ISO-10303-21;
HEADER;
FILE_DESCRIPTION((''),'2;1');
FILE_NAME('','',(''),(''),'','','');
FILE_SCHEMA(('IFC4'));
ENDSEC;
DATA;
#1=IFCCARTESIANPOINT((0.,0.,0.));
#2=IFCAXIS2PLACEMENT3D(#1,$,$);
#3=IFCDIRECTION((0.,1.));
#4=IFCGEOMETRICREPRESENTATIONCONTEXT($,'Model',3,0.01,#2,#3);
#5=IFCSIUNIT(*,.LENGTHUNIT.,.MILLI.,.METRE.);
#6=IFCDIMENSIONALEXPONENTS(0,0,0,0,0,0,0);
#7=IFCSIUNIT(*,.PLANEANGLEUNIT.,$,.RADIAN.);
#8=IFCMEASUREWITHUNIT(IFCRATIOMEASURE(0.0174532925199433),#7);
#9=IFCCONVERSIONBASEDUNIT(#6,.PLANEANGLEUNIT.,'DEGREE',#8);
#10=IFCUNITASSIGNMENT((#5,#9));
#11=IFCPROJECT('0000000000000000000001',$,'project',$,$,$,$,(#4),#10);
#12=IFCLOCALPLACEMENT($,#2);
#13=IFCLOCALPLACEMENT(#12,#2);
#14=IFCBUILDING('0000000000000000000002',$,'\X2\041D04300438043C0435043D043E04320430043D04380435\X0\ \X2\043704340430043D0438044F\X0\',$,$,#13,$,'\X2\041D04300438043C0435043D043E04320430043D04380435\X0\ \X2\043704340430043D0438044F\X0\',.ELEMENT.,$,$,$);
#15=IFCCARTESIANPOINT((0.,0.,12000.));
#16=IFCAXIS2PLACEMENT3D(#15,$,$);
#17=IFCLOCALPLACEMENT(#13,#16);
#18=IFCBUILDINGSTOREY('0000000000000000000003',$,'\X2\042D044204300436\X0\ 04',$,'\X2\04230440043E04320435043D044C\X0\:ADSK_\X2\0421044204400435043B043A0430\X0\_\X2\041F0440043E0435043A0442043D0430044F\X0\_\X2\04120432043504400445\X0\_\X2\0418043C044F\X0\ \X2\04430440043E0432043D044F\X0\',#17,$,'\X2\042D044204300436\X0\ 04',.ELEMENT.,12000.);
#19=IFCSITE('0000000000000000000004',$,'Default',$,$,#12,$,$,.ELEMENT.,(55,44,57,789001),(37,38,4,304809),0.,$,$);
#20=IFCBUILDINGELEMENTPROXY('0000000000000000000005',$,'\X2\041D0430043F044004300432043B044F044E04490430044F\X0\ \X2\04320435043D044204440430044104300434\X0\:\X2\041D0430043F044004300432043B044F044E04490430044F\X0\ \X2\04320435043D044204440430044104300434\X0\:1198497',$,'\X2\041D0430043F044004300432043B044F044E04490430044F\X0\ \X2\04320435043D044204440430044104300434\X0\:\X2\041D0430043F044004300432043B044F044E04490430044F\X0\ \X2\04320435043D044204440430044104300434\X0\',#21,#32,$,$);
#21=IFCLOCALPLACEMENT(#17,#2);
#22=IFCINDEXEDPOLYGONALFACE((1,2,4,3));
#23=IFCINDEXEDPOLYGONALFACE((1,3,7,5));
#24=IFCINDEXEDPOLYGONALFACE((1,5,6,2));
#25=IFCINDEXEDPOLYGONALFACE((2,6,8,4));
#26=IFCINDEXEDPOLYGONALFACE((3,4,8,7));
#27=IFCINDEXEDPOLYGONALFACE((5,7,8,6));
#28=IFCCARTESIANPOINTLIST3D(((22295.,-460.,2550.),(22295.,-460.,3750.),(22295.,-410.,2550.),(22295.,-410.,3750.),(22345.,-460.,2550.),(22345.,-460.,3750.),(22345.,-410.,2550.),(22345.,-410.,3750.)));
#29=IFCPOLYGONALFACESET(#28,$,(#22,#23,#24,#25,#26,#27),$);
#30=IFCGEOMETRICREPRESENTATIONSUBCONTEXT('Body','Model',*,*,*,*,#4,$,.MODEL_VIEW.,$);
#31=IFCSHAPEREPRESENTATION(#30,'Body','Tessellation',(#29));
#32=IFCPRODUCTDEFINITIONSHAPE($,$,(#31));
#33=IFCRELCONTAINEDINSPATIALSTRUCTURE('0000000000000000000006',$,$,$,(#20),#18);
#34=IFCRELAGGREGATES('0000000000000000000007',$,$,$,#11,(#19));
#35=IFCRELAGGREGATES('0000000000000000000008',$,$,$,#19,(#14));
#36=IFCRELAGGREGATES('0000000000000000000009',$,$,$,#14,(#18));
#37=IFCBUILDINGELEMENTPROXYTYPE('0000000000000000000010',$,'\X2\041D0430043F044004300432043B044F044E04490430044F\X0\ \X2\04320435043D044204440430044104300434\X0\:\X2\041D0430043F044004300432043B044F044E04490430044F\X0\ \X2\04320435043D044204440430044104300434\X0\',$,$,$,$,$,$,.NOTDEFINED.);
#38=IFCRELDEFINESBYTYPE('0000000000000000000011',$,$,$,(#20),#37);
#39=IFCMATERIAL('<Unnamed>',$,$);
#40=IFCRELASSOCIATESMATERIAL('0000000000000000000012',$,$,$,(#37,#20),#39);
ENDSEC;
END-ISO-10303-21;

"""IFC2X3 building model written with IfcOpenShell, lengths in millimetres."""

from ifc_helpers import new_model, entity, si_unit, converted_unit, direction, frame, origin, origin_2d_with_axis, place, context, subcontext, project, spatial, rectangle, extrude, source, transform, mapped, material, type_object, type_shapes, element, save


model = new_model("IFC2X3")

# Units and contexts
model_context = context("Model", 3, precision=0.01, world=origin(), true_north=direction((0.0, 1.0)))
body_context = subcontext(model_context, "Body", "Model", "MODEL_VIEW")
ifc_project = project(units=[si_unit("LENGTHUNIT", "METRE", prefix="MILLI"), converted_unit("PLANEANGLEUNIT", "DEGREE", entity("IfcRatioMeasure", 0.0174532925199433), si_unit("PLANEANGLEUNIT", "RADIAN"), dimensions=[0, 0, 0, 0, 0, 0, 0])], contexts=[model_context])

# Site, building, storey
site_placement = place(None, origin())
site = spatial("IfcSite", under=ifc_project, at=site_placement, Name="Default", CompositionType="ELEMENT", RefLatitude=(55, 44, 57, 789001), RefLongitude=(37, 38, 4, 304809), RefElevation=0.0)
building_placement = place(site_placement, origin())
building = spatial("IfcBuilding", under=site, at=building_placement, Name="Наименование здания", LongName="Наименование здания", CompositionType="ELEMENT")
storey_placement = place(building_placement, frame((0.0, 0.0, 12000.0)))
storey = spatial("IfcBuildingStorey", under=building, at=storey_placement, Name="Этаж 04", ObjectType="Уровень:ADSK_Стрелка_Проектная_Вверх_Имя уровня", LongName="Этаж 04", CompositionType="ELEMENT", Elevation=12000.0)

# Building element proxy
ifc_material_1 = material(Name="<Unnamed>")
building_element_proxy_type_1 = type_object("IfcBuildingElementProxyType", Name="Направляющая вентфасад:Направляющая вентфасад", PredefinedType="NOTDEFINED", material=ifc_material_1)
shared_shape_1 = source(origin(), body_context, "Body", "SweptSolid", [
    extrude(rectangle(XDim=50.0, YDim=50.0, at=origin_2d_with_axis()), frame((25.0, -25.0, 0.0), z_axis=(0.0, 0.0, 1.0), x_axis=(-1.0, 0.0, 0.0)), (0.0, 0.0, 1.0), 1200.0),
])
type_shapes(building_element_proxy_type_1, [shared_shape_1])
proxy_1_placement = place(storey_placement, frame((22295.0, -410.0, 2550.0)))
element("IfcBuildingElementProxy", 1, at=proxy_1_placement, inside=storey, type_object=building_element_proxy_type_1, material=ifc_material_1, Name="Направляющая вентфасад:Направляющая вентфасад:1198497", ObjectType="Направляющая вентфасад:Направляющая вентфасад", context=body_context, shape_type="MappedRepresentation", body=[
    mapped(shared_shape_1, transform((0.0, 0.0, 0.0), scale=1.0)),
])

save(model, "model.ifc")
